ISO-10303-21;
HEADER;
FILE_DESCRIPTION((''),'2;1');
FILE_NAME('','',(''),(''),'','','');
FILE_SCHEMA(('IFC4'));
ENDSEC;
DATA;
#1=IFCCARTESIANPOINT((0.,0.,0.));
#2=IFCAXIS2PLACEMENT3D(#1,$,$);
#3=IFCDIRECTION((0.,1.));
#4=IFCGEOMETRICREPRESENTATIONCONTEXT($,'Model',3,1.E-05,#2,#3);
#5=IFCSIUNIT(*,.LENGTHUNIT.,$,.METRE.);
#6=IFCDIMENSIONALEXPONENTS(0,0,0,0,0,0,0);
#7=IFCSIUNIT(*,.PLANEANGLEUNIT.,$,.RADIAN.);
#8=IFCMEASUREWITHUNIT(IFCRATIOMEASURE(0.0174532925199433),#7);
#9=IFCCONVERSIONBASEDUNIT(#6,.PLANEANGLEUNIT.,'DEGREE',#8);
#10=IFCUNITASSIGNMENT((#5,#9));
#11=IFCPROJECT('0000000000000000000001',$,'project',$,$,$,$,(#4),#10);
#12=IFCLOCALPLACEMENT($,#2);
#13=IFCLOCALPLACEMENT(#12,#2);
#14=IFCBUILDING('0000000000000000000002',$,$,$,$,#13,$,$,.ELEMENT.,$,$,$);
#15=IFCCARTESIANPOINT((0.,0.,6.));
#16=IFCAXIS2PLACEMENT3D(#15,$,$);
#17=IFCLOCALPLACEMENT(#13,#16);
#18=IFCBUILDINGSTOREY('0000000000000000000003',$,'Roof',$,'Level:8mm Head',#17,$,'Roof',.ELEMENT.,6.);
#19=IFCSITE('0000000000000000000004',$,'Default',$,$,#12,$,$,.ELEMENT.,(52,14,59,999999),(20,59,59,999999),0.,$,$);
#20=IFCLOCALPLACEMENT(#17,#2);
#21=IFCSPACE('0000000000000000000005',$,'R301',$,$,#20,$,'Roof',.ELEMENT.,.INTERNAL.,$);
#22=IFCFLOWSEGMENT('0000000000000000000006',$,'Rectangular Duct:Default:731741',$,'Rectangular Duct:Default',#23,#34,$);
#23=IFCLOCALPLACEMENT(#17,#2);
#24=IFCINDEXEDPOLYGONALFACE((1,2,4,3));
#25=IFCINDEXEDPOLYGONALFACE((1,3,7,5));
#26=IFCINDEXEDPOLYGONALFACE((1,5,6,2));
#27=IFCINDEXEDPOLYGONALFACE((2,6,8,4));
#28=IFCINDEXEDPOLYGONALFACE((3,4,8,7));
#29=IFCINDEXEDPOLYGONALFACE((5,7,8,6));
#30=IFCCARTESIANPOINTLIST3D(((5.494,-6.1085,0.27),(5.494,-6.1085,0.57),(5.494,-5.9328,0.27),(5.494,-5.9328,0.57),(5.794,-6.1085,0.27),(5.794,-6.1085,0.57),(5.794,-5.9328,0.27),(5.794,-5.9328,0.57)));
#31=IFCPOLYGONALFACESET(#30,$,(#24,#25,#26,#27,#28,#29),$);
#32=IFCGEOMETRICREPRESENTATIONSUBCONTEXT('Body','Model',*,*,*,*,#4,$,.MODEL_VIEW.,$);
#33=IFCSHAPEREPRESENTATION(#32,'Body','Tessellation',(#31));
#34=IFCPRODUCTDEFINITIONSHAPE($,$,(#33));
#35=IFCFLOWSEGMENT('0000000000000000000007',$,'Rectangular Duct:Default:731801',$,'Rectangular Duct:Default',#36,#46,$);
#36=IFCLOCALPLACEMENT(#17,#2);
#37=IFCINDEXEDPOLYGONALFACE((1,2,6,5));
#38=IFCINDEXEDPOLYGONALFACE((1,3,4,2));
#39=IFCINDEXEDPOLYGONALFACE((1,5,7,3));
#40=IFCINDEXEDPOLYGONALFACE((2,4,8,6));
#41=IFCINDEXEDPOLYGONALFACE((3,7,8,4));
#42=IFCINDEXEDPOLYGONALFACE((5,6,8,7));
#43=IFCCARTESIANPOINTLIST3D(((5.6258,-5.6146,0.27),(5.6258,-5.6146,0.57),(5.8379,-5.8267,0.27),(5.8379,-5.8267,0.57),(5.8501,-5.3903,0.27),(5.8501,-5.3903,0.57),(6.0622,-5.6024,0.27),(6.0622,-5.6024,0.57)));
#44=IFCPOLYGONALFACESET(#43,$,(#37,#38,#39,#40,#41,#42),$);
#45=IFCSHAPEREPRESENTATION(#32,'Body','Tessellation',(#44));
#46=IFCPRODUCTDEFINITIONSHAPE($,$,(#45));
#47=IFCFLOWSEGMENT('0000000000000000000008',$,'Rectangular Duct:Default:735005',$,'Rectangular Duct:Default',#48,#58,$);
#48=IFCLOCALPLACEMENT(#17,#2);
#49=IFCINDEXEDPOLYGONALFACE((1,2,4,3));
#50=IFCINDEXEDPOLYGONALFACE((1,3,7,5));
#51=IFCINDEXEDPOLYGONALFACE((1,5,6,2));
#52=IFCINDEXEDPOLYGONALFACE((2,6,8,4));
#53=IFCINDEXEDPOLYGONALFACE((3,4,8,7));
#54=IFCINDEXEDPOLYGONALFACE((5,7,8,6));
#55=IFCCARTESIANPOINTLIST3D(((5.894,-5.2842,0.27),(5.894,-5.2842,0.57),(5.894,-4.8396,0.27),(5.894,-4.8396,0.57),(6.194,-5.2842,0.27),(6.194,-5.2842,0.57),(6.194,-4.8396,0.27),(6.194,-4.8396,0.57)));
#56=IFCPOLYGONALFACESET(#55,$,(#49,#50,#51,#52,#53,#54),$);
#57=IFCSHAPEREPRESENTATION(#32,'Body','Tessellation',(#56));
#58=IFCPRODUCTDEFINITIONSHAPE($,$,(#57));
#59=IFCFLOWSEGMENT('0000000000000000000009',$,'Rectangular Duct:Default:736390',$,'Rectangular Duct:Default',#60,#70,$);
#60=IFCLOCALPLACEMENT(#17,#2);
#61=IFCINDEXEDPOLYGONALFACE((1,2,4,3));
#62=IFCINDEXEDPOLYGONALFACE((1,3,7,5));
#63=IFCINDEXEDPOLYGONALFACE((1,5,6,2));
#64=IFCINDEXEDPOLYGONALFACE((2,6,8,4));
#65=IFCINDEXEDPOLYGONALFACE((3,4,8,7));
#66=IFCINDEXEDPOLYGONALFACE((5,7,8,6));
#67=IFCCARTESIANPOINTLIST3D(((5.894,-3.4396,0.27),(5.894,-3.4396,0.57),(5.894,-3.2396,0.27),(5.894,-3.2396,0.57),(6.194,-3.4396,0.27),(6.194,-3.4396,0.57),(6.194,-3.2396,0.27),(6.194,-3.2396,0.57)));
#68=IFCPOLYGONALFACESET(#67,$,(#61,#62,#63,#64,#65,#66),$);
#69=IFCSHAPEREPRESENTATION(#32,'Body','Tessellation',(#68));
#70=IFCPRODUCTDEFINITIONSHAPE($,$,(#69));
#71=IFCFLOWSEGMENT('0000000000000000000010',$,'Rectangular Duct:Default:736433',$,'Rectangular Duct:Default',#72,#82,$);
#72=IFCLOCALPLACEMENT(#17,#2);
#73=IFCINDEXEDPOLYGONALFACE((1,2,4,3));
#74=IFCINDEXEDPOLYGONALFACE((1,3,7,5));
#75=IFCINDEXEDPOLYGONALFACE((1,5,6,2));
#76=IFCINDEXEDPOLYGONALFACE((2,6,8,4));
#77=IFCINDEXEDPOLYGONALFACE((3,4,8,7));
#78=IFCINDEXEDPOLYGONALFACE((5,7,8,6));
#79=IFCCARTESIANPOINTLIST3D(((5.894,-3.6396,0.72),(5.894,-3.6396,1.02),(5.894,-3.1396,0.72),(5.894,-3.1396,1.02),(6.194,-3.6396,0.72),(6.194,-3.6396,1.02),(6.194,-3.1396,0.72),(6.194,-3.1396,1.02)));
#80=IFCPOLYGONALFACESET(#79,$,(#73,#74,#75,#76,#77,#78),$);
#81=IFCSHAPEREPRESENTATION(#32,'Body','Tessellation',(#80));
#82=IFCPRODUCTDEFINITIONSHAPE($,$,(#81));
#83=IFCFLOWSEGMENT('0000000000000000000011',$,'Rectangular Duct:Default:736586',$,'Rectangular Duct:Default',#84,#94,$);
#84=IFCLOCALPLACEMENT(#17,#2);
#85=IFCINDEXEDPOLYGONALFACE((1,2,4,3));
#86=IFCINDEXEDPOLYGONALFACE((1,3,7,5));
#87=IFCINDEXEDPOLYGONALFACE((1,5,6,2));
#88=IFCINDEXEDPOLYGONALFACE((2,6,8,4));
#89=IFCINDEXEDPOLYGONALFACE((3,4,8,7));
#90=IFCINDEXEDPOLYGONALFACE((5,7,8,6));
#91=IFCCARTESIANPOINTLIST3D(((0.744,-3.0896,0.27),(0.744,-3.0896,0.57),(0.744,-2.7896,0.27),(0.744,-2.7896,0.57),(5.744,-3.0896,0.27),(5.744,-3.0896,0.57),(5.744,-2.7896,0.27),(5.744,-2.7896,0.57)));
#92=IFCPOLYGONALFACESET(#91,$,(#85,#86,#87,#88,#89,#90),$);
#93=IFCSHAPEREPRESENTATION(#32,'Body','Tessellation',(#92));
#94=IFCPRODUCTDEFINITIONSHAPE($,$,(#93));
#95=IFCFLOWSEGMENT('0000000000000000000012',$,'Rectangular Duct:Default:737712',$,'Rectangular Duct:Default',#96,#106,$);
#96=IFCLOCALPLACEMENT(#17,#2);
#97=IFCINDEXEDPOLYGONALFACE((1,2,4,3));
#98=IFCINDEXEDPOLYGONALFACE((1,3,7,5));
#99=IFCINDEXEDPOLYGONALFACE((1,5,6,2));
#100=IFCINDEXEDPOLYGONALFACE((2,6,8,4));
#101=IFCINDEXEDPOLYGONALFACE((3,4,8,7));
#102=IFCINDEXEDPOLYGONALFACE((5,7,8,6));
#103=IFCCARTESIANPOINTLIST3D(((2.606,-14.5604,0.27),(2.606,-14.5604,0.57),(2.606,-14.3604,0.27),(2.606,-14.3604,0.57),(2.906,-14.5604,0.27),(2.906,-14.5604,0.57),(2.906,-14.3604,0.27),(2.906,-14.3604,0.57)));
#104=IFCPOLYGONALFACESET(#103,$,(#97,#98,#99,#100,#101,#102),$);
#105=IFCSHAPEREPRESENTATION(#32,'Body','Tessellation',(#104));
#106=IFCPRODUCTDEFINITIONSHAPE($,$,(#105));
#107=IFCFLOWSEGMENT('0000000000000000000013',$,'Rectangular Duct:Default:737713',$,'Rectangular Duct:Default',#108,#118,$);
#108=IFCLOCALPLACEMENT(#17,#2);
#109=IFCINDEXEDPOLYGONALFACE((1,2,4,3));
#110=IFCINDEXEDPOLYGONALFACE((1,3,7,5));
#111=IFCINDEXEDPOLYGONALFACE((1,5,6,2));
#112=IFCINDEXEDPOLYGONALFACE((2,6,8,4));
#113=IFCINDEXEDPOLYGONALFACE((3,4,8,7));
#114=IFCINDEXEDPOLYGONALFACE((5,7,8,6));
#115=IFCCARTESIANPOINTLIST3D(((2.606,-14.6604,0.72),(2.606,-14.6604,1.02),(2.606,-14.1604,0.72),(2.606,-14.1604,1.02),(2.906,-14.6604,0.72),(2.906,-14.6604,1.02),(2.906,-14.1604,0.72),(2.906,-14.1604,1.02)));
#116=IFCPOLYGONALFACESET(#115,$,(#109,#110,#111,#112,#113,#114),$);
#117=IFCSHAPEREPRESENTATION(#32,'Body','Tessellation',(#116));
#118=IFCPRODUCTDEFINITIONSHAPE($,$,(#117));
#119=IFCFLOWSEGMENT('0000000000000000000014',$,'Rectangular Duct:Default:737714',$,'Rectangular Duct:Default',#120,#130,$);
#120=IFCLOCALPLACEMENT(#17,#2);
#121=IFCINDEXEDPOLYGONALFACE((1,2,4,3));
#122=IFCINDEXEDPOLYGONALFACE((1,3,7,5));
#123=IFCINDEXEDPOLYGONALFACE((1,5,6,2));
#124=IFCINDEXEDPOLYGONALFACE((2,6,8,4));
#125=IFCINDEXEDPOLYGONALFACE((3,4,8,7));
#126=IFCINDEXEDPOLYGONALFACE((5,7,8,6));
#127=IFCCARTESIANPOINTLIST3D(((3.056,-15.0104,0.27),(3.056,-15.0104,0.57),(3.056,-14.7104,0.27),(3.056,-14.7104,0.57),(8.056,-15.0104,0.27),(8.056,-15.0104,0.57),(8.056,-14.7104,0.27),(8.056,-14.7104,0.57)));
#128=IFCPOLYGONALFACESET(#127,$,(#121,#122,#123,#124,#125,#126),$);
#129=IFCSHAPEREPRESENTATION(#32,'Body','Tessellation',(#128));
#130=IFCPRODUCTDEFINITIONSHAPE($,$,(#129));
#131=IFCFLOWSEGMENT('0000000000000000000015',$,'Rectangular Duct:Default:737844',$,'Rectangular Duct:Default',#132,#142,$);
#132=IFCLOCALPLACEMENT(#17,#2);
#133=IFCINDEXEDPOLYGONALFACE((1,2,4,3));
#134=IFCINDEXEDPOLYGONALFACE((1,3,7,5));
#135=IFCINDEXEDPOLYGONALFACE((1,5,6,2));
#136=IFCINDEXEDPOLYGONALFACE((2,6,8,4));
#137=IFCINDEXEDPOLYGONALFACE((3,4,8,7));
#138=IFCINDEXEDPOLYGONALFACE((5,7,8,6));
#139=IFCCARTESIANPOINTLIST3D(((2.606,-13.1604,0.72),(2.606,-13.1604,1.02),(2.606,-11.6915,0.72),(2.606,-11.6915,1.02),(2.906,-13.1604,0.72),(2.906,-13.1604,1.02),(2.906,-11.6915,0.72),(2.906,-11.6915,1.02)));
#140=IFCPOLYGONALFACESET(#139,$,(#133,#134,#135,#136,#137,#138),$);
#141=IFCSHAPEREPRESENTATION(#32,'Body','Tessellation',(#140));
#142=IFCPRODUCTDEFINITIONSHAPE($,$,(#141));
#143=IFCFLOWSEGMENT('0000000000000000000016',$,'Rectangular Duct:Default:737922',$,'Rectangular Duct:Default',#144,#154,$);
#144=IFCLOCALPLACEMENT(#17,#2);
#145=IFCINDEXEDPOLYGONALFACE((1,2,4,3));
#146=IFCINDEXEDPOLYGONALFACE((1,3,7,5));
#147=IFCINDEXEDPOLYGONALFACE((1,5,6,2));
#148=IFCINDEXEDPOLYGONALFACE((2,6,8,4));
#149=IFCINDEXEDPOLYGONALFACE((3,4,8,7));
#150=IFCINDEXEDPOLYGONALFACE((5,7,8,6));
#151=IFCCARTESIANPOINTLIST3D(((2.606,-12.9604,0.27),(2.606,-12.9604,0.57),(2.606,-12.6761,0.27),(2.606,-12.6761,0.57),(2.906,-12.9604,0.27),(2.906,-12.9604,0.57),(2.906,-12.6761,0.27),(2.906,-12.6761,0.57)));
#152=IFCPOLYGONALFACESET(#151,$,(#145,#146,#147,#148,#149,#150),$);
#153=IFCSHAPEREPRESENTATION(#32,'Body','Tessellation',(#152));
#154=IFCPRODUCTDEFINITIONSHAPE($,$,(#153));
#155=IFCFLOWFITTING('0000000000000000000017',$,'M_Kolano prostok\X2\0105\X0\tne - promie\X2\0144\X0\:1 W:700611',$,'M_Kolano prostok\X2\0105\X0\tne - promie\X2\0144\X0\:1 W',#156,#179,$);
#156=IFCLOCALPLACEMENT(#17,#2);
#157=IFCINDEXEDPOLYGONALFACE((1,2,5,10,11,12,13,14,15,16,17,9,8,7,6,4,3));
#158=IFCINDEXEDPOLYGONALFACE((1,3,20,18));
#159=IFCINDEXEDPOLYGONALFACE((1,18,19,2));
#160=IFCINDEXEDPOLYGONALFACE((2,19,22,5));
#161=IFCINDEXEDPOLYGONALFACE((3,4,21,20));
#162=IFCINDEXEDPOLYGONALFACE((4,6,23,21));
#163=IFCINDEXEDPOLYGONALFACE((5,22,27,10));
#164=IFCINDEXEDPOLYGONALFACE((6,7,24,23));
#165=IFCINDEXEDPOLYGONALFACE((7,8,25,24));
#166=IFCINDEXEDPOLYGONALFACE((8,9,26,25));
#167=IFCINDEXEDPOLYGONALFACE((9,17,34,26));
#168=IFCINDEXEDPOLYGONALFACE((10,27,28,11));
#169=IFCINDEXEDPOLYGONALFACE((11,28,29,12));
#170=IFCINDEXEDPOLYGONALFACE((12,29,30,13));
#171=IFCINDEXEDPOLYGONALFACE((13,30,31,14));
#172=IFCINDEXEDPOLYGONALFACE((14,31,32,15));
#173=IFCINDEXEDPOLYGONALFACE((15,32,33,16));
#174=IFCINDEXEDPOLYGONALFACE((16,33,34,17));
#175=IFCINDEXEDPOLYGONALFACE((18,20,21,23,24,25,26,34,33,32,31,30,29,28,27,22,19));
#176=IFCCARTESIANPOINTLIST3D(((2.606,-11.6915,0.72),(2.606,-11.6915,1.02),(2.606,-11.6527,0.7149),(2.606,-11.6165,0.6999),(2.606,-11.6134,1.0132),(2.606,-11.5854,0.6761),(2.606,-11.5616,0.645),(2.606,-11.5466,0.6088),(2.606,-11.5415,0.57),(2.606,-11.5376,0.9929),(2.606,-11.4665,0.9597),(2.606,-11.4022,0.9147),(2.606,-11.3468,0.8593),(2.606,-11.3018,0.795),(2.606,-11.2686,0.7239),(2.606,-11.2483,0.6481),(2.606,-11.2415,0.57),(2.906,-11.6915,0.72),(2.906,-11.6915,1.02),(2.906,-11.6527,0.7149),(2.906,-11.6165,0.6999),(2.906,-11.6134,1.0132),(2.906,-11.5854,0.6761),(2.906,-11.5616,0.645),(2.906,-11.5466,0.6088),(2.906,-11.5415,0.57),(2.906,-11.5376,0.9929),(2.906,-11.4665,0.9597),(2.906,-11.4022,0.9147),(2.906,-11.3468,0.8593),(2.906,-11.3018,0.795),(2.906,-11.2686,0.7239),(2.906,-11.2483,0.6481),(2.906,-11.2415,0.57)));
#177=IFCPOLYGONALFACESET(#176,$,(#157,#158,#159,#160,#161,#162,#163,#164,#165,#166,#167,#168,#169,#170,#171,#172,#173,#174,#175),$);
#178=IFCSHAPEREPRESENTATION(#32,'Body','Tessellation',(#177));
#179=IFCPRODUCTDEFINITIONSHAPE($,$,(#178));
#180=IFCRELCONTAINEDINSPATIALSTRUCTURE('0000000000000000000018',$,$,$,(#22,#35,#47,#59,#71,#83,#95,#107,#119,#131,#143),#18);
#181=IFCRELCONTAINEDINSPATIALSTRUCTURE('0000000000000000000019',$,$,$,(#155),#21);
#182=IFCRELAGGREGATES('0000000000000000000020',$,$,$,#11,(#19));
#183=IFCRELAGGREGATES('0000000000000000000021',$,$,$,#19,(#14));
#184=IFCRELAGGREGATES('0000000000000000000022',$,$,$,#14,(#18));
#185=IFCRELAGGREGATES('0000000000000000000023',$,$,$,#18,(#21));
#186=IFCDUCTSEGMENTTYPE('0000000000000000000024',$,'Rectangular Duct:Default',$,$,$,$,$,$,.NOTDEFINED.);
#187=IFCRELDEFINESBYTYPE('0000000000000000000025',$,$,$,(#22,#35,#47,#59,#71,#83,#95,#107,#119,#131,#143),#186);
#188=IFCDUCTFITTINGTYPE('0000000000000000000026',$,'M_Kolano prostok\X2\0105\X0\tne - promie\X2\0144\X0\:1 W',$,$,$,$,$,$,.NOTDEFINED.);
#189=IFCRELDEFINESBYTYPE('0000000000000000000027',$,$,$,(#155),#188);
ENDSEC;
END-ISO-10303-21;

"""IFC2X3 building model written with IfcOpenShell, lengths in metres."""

from ifc_helpers import new_model, entity, si_unit, converted_unit, direction, frame, frame_2d, origin, origin_2d_with_axis, place, context, subcontext, project, spatial, polyline, circle_curve, parameter, trimmed, segment, composite_curve, rectangle, outline, extrude, source, transform, mapped, type_object, type_shapes, element, save


model = new_model("IFC2X3")

# Units and contexts
model_context = context("Model", 3, precision=1e-05, world=origin(), true_north=direction((0.0, 1.0)))
body_context = subcontext(model_context, "Body", "Model", "MODEL_VIEW")
ifc_project = project(units=[si_unit("LENGTHUNIT", "METRE"), converted_unit("PLANEANGLEUNIT", "DEGREE", entity("IfcRatioMeasure", 0.0174532925199433), si_unit("PLANEANGLEUNIT", "RADIAN"), dimensions=[0, 0, 0, 0, 0, 0, 0])], contexts=[model_context])

# Site, building, storey
site_placement = place(None, origin())
site = spatial("IfcSite", under=ifc_project, at=site_placement, Name="Default", CompositionType="ELEMENT", RefLatitude=(52, 14, 59, 999999), RefLongitude=(20, 59, 59, 999999), RefElevation=0.0)
building_placement = place(site_placement, origin())
building = spatial("IfcBuilding", under=site, at=building_placement, CompositionType="ELEMENT")
storey_placement = place(building_placement, frame((0.0, 0.0, 6.0)))
storey = spatial("IfcBuildingStorey", under=building, at=storey_placement, Name="Roof", ObjectType="Level:8mm Head", LongName="Roof", CompositionType="ELEMENT", Elevation=6.0)

# Flow segments
duct_segment_type = type_object("IfcDuctSegmentType", Name="Rectangular Duct:Default", PredefinedType="NOTDEFINED")
flow_segment_1_placement = place(storey_placement, origin())
element("IfcFlowSegment", 1, at=flow_segment_1_placement, inside=storey, type_object=duct_segment_type, Name="Rectangular Duct:Default:731741", ObjectType="Rectangular Duct:Default", context=body_context, shape_type="SweptSolid", body=[
    extrude(rectangle(XDim=0.1757, YDim=0.3, at=origin_2d_with_axis()), frame((5.644, -6.0206, 0.27), z_axis=(0.0, 0.0, 1.0), x_axis=(0.0, 1.0, 0.0)), (0.0, 0.0, 1.0), 0.3),
])
flow_segment_2_placement = place(storey_placement, origin())
element("IfcFlowSegment", 2, at=flow_segment_2_placement, inside=storey, type_object=duct_segment_type, Name="Rectangular Duct:Default:731801", ObjectType="Rectangular Duct:Default", context=body_context, shape_type="SweptSolid", body=[
    extrude(rectangle(XDim=0.3172, YDim=0.3, at=origin_2d_with_axis()), frame((5.844, -5.6085, 0.27), z_axis=(0.0, 0.0, 1.0), x_axis=(0.707107, 0.707107, 0.0)), (0.0, 0.0, 1.0), 0.3),
])
flow_segment_3_placement = place(storey_placement, origin())
element("IfcFlowSegment", 3, at=flow_segment_3_placement, inside=storey, type_object=duct_segment_type, Name="Rectangular Duct:Default:735005", ObjectType="Rectangular Duct:Default", context=body_context, shape_type="SweptSolid", body=[
    extrude(rectangle(XDim=0.4446, YDim=0.3, at=frame_2d((0.0, 0.0), x_axis=(1.0, 0.0))), frame((6.044, -5.0619, 0.27), z_axis=(0.0, 0.0, 1.0), x_axis=(0.0, 1.0, 0.0)), (0.0, 0.0, 1.0), 0.3),
])
flow_segment_4_placement = place(storey_placement, origin())
element("IfcFlowSegment", 4, at=flow_segment_4_placement, inside=storey, type_object=duct_segment_type, Name="Rectangular Duct:Default:736390", ObjectType="Rectangular Duct:Default", context=body_context, shape_type="SweptSolid", body=[
    extrude(rectangle(XDim=0.2, YDim=0.3, at=frame_2d((0.0, 0.0), x_axis=(1.0, 0.0))), frame((6.044, -3.3396, 0.27), z_axis=(0.0, 0.0, 1.0), x_axis=(0.0, 1.0, 0.0)), (0.0, 0.0, 1.0), 0.3),
])
flow_segment_5_placement = place(storey_placement, origin())
element("IfcFlowSegment", 5, at=flow_segment_5_placement, inside=storey, type_object=duct_segment_type, Name="Rectangular Duct:Default:736433", ObjectType="Rectangular Duct:Default", context=body_context, shape_type="SweptSolid", body=[
    extrude(rectangle(XDim=0.5, YDim=0.3, at=frame_2d((0.0, 0.0), x_axis=(1.0, 0.0))), frame((6.044, -3.3896, 0.72), z_axis=(0.0, 0.0, 1.0), x_axis=(0.0, 1.0, 0.0)), (0.0, 0.0, 1.0), 0.3),
])
flow_segment_6_placement = place(storey_placement, origin())
element("IfcFlowSegment", 6, at=flow_segment_6_placement, inside=storey, type_object=duct_segment_type, Name="Rectangular Duct:Default:736586", ObjectType="Rectangular Duct:Default", context=body_context, shape_type="SweptSolid", body=[
    extrude(rectangle(XDim=5.0, YDim=0.3, at=frame_2d((0.0, 0.0), x_axis=(1.0, 0.0))), frame((3.244, -2.9396, 0.27), z_axis=(0.0, 0.0, 1.0), x_axis=(-1.0, 0.0, 0.0)), (0.0, 0.0, 1.0), 0.3),
])
flow_segment_7_placement = place(storey_placement, origin())
element("IfcFlowSegment", 7, at=flow_segment_7_placement, inside=storey, type_object=duct_segment_type, Name="Rectangular Duct:Default:737712", ObjectType="Rectangular Duct:Default", context=body_context, shape_type="SweptSolid", body=[
    extrude(rectangle(XDim=0.2, YDim=0.3, at=frame_2d((0.0, 0.0), x_axis=(1.0, 0.0))), frame((2.756, -14.4604, 0.27), z_axis=(0.0, 0.0, 1.0), x_axis=(0.0, -1.0, 0.0)), (0.0, 0.0, 1.0), 0.3),
])
flow_segment_8_placement = place(storey_placement, origin())
element("IfcFlowSegment", 8, at=flow_segment_8_placement, inside=storey, type_object=duct_segment_type, Name="Rectangular Duct:Default:737713", ObjectType="Rectangular Duct:Default", context=body_context, shape_type="SweptSolid", body=[
    extrude(rectangle(XDim=0.5, YDim=0.3, at=frame_2d((0.0, 0.0), x_axis=(1.0, 0.0))), frame((2.756, -14.4104, 0.72), z_axis=(0.0, 0.0, 1.0), x_axis=(0.0, -1.0, 0.0)), (0.0, 0.0, 1.0), 0.3),
])
flow_segment_9_placement = place(storey_placement, origin())
element("IfcFlowSegment", 9, at=flow_segment_9_placement, inside=storey, type_object=duct_segment_type, Name="Rectangular Duct:Default:737714", ObjectType="Rectangular Duct:Default", context=body_context, shape_type="SweptSolid", body=[
    extrude(rectangle(XDim=5.0, YDim=0.3, at=frame_2d((0.0, 0.0), x_axis=(1.0, 0.0))), frame((5.556, -14.8604, 0.27)), (0.0, 0.0, 1.0), 0.3),
])
flow_segment_10_placement = place(storey_placement, origin())
element("IfcFlowSegment", 10, at=flow_segment_10_placement, inside=storey, type_object=duct_segment_type, Name="Rectangular Duct:Default:737844", ObjectType="Rectangular Duct:Default", context=body_context, shape_type="SweptSolid", body=[
    extrude(rectangle(XDim=1.4689, YDim=0.3, at=frame_2d((0.0, 0.0), x_axis=(1.0, 0.0))), frame((2.756, -12.4259, 0.72), z_axis=(0.0, 0.0, 1.0), x_axis=(0.0, -1.0, 0.0)), (0.0, 0.0, 1.0), 0.3),
])
flow_segment_11_placement = place(storey_placement, origin())
element("IfcFlowSegment", 11, at=flow_segment_11_placement, inside=storey, type_object=duct_segment_type, Name="Rectangular Duct:Default:737922", ObjectType="Rectangular Duct:Default", context=body_context, shape_type="SweptSolid", body=[
    extrude(rectangle(XDim=0.2843, YDim=0.3, at=frame_2d((0.0, 0.0), x_axis=(1.0, 0.0))), frame((2.756, -12.8182, 0.27), z_axis=(0.0, 0.0, 1.0), x_axis=(0.0, 1.0, 0.0)), (0.0, 0.0, 1.0), 0.3),
])

# Shared definitions
space_placement = place(storey_placement, origin())
space = spatial("IfcSpace", under=storey, at=space_placement, Name="R301", LongName="Roof", CompositionType="ELEMENT", InteriorOrExteriorSpace="INTERNAL")

# Flow fitting
duct_fitting_type_1 = type_object("IfcDuctFittingType", Name="M_Kolano prostokątne - promień:1 W", PredefinedType="NOTDEFINED")
shared_shape_1 = source(origin(), body_context, "Body", "SweptSolid", [
    extrude(outline(composite_curve([segment(polyline([(-0.3, -0.15), (0.0, -0.15)]), True, "CONTINUOUS"), segment(trimmed(circle_curve(frame_2d((0.15, -0.15), x_axis=(0.0, 1.0)), 0.15), [parameter(0.0)], [parameter(90.0)], True, "PARAMETER"), False, "CONTINUOUS"), segment(polyline([(0.15, 0.0), (0.15, 0.3)]), True, "CONTINUOUS"), segment(trimmed(circle_curve(frame_2d((0.15, -0.15), x_axis=(0.0, 1.0)), 0.45), [parameter(0.0)], [parameter(90.0)], True, "PARAMETER"), True, "CONTINUOUS")], self_intersect=False)), frame((-0.15, 0.15, -0.15), z_axis=(0.0, 0.0, 1.0), x_axis=(-1.0, 0.0, 0.0)), (0.0, 0.0, 1.0), 0.3),
])
type_shapes(duct_fitting_type_1, [shared_shape_1])
for number, where, z_axis, x_axis, name in (
    (12, (2.756, -11.3915, 0.87), (1.0, 0.0, 0.0), (0.0, 0.0, 1.0), "M_Kolano prostokątne - promień:1 W:700611"),
):
    element("IfcFlowFitting", number, at=place(space_placement, frame(where, z_axis=z_axis, x_axis=x_axis)), inside=space, type_object=duct_fitting_type_1, Name=name, ObjectType="M_Kolano prostokątne - promień:1 W", context=body_context, shape_type="MappedRepresentation", body=[
        mapped(shared_shape_1, transform((0.0, 0.0, 0.0), scale=1.0)),
    ])

save(model, "model.ifc")
